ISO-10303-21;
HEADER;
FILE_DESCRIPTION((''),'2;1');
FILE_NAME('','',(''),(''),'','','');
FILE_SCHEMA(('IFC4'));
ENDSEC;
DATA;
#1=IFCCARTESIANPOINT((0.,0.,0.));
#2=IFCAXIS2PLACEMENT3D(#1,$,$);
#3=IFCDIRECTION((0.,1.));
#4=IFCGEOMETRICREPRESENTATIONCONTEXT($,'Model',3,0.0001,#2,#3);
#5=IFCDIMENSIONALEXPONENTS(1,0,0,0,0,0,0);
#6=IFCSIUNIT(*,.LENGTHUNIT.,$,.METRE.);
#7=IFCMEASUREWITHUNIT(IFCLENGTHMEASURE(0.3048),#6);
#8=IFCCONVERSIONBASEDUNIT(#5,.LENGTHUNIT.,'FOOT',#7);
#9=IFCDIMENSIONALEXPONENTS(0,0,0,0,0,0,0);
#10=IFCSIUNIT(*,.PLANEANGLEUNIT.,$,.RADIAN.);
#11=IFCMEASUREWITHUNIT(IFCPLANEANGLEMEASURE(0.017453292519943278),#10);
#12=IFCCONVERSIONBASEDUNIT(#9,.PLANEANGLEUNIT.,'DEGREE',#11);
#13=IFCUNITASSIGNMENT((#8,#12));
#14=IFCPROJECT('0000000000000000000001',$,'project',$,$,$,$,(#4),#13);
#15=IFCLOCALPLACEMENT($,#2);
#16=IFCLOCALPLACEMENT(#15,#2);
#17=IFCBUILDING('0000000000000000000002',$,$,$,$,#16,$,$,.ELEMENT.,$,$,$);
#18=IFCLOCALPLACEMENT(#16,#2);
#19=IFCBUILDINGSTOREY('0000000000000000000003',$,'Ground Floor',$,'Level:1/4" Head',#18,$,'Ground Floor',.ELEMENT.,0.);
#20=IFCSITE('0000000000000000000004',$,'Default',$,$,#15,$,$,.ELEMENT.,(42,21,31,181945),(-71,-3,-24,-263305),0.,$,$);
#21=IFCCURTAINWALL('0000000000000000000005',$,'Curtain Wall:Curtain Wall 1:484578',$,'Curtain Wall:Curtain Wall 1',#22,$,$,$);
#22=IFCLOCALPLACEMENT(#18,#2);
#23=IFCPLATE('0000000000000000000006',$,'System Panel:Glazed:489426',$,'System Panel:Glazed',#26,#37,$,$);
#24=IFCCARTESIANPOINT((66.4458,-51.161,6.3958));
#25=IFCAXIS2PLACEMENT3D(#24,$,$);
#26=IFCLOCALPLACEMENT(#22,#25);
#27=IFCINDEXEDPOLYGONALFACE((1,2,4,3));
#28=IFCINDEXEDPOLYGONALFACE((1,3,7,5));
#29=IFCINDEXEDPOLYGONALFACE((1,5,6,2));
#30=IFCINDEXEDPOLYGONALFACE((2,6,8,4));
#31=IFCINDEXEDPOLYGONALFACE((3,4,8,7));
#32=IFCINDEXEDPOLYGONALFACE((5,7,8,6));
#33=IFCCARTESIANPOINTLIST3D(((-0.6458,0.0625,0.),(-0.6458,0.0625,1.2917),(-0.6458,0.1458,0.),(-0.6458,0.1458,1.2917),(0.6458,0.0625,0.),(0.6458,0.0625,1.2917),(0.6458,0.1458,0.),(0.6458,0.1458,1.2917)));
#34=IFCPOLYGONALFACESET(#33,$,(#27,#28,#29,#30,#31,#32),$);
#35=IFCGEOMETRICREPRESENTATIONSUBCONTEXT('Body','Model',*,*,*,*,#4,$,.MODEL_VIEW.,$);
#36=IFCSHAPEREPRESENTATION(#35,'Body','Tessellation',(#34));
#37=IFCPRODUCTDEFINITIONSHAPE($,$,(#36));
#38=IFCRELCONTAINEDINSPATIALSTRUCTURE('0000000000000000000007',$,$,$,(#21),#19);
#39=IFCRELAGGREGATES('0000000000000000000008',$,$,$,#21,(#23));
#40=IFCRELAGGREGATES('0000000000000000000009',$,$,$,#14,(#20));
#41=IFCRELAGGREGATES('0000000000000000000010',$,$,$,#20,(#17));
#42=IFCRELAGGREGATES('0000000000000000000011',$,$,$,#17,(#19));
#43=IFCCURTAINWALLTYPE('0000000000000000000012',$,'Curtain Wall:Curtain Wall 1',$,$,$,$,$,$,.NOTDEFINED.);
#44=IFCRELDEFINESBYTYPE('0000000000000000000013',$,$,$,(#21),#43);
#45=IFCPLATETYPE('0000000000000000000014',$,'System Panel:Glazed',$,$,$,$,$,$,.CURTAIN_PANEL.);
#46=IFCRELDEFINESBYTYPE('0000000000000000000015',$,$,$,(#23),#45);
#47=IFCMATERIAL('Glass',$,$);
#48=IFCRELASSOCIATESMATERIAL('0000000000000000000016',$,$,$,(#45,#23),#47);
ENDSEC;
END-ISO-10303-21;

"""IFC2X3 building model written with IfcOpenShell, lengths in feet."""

from ifc_helpers import new_model, entity, si_unit, converted_unit, direction, frame, frame_2d, origin, place, context, subcontext, project, spatial, rectangle, extrude, source, transform, mapped, material, type_object, type_shapes, element, aggregate, save


model = new_model("IFC2X3")

# Units and contexts
model_context = context("Model", 3, precision=0.0001, world=origin(), true_north=direction((0.0, 1.0)))
body_context = subcontext(model_context, "Body", "Model", "MODEL_VIEW")
ifc_project = project(units=[converted_unit("LENGTHUNIT", "FOOT", entity("IfcLengthMeasure", 0.3048), si_unit("LENGTHUNIT", "METRE"), dimensions=[1, 0, 0, 0, 0, 0, 0]), converted_unit("PLANEANGLEUNIT", "DEGREE", entity("IfcPlaneAngleMeasure", 0.017453292519943278), si_unit("PLANEANGLEUNIT", "RADIAN"), dimensions=[0, 0, 0, 0, 0, 0, 0])], contexts=[model_context])

# Site, building, storey
site_placement = place(None, origin())
site = spatial("IfcSite", under=ifc_project, at=site_placement, Name="Default", CompositionType="ELEMENT", RefLatitude=(42, 21, 31, 181945), RefLongitude=(-71, -3, -24, -263305), RefElevation=0.0)
building_placement = place(site_placement, origin())
building = spatial("IfcBuilding", under=site, at=building_placement, CompositionType="ELEMENT")
storey_placement = place(building_placement, origin())
storey = spatial("IfcBuildingStorey", under=building, at=storey_placement, Name="Ground Floor", ObjectType="Level:1/4\" Head", LongName="Ground Floor", CompositionType="ELEMENT", Elevation=0.0)

# Curtain wall, plate
curtain_wall_type = type_object("IfcCurtainWallType", Name="Curtain Wall:Curtain Wall 1", PredefinedType="NOTDEFINED")
curtain_wall_placement = place(storey_placement, origin())
curtain_wall = element("IfcCurtainWall", 1, at=curtain_wall_placement, inside=storey, type_object=curtain_wall_type, Name="Curtain Wall:Curtain Wall 1:484578", ObjectType="Curtain Wall:Curtain Wall 1")
ifc_material_1 = material(Name="Glass")
plate_type_1 = type_object("IfcPlateType", Name="System Panel:Glazed", PredefinedType="CURTAIN_PANEL", material=ifc_material_1)
shared_shape_1 = source(origin(), body_context, "Body", "SweptSolid", [
    extrude(rectangle(XDim=0.0833, YDim=1.2917, at=frame_2d((0.0, 0.0), x_axis=(1.0, 0.0))), frame((0.0, 0.1042, 0.0), z_axis=(0.0, 0.0, 1.0), x_axis=(0.0, 1.0, 0.0)), (0.0, 0.0, 1.0), 1.2917),
])
type_shapes(plate_type_1, [shared_shape_1])
plate_1_placement = place(curtain_wall_placement, frame((66.4458, -51.161, 6.3958)))
plate_1 = element("IfcPlate", 2, at=plate_1_placement, type_object=plate_type_1, material=ifc_material_1, Name="System Panel:Glazed:489426", ObjectType="System Panel:Glazed", context=body_context, shape_type="MappedRepresentation", body=[
    mapped(shared_shape_1, transform((0.0, 0.0, 0.0), scale=1.0)),
])
aggregate(curtain_wall, [plate_1])

save(model, "model.ifc")
